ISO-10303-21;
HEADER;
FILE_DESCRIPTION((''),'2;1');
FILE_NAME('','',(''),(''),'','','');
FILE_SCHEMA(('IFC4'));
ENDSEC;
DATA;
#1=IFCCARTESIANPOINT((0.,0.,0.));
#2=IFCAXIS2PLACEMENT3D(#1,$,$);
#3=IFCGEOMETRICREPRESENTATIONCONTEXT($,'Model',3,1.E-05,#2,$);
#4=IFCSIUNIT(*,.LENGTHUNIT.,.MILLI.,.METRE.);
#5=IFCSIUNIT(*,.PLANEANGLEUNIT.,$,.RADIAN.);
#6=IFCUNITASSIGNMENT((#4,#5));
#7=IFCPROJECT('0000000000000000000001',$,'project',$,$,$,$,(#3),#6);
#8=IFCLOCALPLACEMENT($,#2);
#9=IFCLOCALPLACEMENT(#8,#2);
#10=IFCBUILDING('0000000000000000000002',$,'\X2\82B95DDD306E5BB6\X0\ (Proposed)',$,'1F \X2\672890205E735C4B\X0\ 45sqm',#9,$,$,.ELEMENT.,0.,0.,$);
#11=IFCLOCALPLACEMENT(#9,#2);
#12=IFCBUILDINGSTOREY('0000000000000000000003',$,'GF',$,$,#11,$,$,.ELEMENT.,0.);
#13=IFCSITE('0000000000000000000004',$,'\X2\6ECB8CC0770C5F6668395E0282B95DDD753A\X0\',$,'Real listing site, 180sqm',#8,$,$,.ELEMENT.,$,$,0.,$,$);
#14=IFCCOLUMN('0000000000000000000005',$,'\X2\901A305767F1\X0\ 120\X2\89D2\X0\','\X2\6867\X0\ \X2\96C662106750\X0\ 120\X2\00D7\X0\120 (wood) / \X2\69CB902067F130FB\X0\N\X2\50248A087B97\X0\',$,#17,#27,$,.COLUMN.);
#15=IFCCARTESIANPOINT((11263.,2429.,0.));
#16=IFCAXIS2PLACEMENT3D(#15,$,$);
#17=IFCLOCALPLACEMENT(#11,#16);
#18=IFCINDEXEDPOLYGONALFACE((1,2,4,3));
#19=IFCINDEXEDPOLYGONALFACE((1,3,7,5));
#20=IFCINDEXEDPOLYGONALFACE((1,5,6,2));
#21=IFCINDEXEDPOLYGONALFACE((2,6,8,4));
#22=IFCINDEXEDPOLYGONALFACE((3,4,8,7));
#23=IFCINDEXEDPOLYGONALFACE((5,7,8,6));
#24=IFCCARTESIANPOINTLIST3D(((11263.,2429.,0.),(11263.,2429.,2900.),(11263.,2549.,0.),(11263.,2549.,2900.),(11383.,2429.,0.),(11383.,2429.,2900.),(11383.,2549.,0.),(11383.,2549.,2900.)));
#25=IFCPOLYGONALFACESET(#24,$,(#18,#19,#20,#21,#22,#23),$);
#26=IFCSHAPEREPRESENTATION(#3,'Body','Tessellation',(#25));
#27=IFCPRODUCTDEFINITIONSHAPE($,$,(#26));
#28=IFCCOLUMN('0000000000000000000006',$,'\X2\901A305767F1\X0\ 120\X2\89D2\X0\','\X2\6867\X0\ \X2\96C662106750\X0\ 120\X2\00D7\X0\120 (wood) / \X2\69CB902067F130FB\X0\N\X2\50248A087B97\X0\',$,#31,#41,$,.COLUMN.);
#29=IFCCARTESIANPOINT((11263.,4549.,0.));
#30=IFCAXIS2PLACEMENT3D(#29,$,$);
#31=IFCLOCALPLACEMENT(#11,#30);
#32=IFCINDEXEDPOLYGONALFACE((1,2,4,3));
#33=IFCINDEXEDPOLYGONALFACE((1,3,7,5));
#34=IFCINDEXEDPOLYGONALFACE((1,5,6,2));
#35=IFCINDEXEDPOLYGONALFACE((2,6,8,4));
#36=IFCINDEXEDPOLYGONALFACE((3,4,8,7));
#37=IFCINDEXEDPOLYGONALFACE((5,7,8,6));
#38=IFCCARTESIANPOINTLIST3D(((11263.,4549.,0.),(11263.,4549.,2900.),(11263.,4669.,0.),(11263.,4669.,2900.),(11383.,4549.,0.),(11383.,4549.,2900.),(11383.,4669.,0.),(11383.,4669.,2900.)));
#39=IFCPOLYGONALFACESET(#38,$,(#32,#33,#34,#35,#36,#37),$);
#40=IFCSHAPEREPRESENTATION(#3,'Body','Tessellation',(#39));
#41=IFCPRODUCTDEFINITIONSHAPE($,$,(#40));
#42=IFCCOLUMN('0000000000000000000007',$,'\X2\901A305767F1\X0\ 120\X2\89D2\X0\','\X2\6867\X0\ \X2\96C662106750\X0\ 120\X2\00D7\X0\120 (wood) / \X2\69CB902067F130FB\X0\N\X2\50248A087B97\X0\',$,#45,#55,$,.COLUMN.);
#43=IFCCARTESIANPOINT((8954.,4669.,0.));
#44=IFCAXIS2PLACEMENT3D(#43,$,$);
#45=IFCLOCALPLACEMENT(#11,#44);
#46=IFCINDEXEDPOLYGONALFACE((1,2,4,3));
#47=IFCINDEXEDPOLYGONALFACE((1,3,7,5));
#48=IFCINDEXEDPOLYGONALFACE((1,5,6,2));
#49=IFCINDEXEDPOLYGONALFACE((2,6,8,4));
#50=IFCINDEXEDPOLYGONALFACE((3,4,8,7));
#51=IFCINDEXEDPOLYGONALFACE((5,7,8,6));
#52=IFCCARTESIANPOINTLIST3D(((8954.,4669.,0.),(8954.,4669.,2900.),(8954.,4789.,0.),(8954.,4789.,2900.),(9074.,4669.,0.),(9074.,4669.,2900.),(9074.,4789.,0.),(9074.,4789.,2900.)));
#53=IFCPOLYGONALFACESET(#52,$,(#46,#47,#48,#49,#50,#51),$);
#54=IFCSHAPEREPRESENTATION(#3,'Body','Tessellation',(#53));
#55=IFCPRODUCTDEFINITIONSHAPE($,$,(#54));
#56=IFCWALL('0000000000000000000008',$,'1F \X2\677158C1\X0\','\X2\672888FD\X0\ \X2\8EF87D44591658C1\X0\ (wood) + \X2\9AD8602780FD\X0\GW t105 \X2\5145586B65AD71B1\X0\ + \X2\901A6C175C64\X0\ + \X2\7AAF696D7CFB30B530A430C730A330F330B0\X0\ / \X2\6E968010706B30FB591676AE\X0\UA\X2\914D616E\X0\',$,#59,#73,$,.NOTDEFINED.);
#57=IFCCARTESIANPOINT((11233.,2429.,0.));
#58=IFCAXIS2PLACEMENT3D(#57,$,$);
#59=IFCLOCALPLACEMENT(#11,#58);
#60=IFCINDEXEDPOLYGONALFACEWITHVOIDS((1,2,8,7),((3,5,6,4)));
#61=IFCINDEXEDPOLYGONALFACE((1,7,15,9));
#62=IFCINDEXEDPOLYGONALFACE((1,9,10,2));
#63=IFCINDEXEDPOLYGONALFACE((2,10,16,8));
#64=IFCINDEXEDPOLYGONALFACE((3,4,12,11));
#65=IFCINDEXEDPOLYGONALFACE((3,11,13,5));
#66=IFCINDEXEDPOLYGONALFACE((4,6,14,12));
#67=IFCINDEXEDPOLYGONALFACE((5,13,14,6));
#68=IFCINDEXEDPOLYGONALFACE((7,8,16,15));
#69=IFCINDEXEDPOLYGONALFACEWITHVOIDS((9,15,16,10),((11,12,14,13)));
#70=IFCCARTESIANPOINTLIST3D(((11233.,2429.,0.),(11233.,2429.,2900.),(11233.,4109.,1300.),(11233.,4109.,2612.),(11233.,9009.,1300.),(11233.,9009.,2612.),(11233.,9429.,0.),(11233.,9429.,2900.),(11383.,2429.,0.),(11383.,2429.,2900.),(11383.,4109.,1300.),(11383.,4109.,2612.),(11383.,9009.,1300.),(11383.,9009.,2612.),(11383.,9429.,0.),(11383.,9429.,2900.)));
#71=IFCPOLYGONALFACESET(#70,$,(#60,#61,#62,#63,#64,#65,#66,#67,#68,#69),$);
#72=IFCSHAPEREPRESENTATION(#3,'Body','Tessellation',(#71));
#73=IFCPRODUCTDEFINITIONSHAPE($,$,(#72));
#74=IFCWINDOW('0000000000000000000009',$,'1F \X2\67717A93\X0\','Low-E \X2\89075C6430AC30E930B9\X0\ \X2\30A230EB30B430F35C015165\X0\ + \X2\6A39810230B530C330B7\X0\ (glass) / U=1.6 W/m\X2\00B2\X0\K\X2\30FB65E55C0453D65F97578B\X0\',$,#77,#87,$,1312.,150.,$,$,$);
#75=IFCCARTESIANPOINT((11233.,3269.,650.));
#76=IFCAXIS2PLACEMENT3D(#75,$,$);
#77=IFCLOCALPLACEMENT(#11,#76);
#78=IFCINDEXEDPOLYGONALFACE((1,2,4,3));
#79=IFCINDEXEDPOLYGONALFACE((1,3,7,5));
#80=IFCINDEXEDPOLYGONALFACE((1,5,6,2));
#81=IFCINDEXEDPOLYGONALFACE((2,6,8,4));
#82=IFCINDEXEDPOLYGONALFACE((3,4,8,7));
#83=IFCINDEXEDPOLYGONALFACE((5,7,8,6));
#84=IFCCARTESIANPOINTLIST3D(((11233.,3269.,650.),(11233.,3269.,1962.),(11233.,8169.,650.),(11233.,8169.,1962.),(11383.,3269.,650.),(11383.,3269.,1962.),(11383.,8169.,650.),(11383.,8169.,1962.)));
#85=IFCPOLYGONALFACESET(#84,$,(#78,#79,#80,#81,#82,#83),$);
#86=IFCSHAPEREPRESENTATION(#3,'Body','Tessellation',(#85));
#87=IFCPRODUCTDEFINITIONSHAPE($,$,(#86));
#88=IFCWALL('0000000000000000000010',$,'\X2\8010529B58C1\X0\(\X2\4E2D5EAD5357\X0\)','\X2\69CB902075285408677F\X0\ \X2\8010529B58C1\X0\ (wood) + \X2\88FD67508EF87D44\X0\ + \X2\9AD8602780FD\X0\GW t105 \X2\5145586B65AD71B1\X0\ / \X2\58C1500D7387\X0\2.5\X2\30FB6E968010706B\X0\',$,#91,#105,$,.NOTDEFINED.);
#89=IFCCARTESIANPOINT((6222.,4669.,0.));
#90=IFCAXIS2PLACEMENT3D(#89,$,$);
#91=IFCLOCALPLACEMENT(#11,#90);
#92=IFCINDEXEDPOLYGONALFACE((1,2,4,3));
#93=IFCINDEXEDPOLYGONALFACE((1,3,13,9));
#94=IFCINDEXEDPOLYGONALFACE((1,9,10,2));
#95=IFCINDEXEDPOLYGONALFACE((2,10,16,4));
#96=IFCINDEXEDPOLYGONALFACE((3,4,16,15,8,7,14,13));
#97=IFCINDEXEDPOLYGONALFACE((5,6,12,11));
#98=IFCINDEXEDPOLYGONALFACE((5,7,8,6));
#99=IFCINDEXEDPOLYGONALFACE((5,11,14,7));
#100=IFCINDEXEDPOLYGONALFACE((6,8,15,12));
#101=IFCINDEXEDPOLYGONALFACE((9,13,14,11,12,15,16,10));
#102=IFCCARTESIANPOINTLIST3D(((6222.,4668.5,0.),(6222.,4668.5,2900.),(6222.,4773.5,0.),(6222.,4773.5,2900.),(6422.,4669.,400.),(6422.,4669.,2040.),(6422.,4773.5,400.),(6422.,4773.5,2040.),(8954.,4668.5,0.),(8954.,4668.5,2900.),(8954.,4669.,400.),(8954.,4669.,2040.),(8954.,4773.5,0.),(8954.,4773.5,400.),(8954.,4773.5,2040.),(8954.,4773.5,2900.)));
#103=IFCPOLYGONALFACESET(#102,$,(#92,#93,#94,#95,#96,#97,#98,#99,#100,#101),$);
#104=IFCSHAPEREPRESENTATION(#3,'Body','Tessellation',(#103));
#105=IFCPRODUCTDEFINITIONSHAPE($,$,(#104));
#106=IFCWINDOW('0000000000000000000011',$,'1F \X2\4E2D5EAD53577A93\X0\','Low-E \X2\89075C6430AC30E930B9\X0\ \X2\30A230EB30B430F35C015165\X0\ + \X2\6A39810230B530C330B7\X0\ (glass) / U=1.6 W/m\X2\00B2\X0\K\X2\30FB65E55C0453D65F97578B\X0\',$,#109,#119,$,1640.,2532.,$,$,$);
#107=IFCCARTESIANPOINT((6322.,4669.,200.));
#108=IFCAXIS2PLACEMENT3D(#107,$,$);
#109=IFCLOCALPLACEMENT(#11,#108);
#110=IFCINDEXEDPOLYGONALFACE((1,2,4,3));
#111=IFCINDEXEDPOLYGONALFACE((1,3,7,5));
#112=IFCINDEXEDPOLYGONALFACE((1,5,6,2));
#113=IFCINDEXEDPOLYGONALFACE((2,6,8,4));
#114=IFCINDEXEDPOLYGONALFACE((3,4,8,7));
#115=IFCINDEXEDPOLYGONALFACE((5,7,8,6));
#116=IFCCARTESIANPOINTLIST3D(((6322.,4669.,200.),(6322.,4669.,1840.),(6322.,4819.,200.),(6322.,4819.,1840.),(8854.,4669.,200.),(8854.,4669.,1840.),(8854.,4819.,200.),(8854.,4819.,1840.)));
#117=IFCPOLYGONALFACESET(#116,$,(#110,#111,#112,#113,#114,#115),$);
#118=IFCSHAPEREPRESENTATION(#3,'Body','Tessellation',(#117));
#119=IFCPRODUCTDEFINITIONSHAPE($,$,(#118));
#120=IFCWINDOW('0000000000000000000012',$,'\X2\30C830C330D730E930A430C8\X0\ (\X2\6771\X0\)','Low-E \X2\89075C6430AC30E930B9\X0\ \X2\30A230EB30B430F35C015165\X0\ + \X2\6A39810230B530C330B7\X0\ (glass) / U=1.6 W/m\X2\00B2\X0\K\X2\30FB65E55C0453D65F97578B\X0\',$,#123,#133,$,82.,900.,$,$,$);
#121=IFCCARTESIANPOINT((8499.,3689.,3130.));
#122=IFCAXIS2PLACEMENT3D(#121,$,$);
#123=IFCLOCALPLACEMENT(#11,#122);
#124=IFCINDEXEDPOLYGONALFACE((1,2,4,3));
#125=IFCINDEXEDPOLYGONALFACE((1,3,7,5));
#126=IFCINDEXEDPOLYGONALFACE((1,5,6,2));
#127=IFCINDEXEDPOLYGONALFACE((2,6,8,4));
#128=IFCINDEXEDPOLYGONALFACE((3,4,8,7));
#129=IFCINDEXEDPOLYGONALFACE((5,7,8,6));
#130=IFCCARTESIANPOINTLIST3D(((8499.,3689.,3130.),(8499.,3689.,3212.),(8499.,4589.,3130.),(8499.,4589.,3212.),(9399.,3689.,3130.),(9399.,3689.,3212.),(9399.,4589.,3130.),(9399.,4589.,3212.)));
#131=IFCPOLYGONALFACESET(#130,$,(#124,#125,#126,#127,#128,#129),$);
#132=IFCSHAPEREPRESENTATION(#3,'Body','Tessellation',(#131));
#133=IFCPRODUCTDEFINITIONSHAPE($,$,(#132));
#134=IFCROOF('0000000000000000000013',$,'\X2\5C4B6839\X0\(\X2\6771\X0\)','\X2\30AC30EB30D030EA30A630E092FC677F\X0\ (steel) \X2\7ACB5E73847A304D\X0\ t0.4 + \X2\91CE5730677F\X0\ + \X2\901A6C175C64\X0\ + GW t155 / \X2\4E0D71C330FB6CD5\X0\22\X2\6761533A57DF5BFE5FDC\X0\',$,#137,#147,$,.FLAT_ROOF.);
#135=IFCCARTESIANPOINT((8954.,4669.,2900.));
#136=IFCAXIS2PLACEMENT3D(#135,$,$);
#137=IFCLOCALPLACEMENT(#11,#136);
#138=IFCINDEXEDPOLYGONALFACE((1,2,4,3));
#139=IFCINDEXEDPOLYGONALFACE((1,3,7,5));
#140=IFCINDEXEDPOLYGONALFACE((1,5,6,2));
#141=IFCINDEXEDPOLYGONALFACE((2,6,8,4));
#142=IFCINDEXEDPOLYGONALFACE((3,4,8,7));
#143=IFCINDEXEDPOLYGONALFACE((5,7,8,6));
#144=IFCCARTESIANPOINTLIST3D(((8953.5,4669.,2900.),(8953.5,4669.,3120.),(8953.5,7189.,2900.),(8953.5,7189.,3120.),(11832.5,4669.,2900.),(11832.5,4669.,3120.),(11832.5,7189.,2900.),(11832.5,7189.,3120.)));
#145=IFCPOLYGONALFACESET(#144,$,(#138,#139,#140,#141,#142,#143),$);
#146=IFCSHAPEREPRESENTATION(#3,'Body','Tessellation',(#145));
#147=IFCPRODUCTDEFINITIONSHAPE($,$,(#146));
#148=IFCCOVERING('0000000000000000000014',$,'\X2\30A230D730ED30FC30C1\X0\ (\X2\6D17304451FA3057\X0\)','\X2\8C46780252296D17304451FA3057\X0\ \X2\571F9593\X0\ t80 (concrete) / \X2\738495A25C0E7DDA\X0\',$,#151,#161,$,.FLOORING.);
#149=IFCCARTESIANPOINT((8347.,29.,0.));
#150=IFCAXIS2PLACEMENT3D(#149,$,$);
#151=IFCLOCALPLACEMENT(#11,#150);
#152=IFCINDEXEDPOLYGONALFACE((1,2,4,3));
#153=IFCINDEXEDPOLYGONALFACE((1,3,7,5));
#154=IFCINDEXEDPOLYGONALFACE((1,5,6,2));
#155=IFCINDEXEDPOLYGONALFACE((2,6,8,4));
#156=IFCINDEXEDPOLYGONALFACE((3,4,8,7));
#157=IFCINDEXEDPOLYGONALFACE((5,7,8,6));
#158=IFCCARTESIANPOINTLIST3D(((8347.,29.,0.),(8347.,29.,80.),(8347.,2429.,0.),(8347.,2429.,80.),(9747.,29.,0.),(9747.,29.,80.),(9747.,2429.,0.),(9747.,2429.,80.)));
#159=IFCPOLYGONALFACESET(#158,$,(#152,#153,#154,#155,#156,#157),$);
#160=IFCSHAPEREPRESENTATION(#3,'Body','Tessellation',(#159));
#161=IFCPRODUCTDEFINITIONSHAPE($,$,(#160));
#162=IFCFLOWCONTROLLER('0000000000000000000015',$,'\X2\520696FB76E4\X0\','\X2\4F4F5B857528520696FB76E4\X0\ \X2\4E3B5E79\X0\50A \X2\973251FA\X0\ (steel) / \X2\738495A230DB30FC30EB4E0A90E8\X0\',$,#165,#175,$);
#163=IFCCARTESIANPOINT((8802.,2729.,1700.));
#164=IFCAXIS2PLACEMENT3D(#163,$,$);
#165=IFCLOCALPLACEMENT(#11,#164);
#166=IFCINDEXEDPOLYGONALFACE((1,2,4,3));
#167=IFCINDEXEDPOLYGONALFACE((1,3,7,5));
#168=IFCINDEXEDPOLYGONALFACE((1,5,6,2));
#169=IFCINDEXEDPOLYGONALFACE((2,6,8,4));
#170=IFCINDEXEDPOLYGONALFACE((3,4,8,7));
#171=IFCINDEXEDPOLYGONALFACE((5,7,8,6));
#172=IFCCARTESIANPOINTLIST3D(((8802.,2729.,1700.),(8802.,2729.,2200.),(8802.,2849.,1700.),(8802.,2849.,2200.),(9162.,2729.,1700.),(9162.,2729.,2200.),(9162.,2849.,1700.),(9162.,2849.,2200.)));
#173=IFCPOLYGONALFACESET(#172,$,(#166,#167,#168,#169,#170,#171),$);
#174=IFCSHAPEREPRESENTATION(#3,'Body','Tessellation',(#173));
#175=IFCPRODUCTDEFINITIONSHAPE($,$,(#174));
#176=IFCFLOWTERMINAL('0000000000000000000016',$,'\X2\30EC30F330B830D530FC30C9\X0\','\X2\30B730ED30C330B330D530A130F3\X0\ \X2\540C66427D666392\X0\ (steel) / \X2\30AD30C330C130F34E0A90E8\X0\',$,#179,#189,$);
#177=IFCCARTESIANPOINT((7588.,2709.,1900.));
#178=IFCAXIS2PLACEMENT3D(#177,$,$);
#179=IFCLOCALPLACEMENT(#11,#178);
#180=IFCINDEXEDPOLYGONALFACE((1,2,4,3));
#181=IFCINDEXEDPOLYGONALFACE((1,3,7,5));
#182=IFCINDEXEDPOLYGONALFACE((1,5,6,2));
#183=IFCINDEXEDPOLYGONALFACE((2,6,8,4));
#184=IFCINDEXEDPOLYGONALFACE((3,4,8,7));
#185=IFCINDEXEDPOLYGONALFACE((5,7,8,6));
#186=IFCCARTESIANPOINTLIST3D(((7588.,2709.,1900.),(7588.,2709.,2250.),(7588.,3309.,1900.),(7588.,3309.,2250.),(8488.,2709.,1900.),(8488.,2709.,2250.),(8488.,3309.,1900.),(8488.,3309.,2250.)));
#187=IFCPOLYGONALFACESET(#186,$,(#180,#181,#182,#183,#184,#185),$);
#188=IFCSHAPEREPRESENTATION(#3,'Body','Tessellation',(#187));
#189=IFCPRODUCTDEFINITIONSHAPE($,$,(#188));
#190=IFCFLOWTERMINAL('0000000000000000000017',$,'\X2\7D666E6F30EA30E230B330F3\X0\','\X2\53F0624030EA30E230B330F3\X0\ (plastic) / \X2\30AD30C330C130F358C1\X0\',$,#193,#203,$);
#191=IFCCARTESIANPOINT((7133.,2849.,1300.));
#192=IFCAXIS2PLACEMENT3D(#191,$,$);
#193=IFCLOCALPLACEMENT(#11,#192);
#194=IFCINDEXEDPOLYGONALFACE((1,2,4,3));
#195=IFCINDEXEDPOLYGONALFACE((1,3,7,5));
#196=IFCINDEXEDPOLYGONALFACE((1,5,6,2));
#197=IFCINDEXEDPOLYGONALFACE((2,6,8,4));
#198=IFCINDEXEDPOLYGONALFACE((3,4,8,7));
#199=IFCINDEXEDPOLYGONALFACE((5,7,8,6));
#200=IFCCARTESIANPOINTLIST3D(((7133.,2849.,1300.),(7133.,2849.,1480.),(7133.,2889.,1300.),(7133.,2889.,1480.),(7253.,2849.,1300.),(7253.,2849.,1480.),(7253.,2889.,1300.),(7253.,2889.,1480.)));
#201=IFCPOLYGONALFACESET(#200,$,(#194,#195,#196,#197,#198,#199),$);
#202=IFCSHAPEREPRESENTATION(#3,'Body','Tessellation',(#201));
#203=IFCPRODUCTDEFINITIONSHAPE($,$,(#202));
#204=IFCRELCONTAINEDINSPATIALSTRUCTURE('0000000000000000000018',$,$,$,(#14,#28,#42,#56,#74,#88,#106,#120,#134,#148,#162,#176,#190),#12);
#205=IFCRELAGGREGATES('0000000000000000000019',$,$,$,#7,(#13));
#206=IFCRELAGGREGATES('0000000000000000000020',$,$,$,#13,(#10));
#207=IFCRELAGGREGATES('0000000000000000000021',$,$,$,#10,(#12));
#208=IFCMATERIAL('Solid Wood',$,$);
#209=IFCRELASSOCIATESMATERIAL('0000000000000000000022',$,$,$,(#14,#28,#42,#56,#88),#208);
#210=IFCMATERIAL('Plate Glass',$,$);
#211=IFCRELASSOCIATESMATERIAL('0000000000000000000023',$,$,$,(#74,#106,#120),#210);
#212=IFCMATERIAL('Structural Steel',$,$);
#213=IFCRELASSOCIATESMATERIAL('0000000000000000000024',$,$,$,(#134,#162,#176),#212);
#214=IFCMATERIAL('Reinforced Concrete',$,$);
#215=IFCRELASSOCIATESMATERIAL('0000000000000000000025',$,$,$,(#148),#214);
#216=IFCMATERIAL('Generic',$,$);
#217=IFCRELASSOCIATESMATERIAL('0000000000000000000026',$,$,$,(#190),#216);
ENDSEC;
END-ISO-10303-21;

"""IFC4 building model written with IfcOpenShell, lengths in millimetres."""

from ifc_helpers import new_model, si_unit, frame, frame_2d, origin, place, context, project, spatial, rectangle, extrude, material, element, fill, save


model = new_model("IFC4")

# Units and contexts
model_context = context("Model", 3, precision=1e-05, world=origin())
ifc_project = project(units=[si_unit("LENGTHUNIT", "METRE", prefix="MILLI"), si_unit("PLANEANGLEUNIT", "RADIAN")], contexts=[model_context])

# Site, building, storey
site_placement = place(None, origin())
site = spatial("IfcSite", under=ifc_project, at=site_placement, Name="滋賀県彦根市芹川町", ObjectType="Real listing site, 180sqm", CompositionType="ELEMENT", RefElevation=0.0)
building_placement = place(site_placement, origin())
building = spatial("IfcBuilding", under=site, at=building_placement, Name="芹川の家 (Proposed)", ObjectType="1F 木造平屋 45sqm", CompositionType="ELEMENT", ElevationOfRefHeight=0.0, ElevationOfTerrain=0.0)
storey_placement = place(building_placement, origin())
storey = spatial("IfcBuildingStorey", under=building, at=storey_placement, Name="GF", CompositionType="ELEMENT", Elevation=0.0)

# Columns
ifc_material_1 = material(Name="Solid Wood")
column_1_placement = place(storey_placement, frame((11263.0, 2429.0, 0.0)))
element("IfcColumn", 1, at=column_1_placement, inside=storey, material=ifc_material_1, Name="通し柱 120角", Description="桧 集成材 120×120 (wood) / 構造柱・N値計算", PredefinedType="COLUMN", context=model_context, shape_type="SweptSolid", body=[
    extrude(rectangle(XDim=120.0, YDim=120.0, at=frame_2d((60.0, 60.0))), frame((11263.0, 2429.0, 0.0)), (0.0, 0.0, 1.0), 2900.0),
])
column_2_placement = place(storey_placement, frame((11263.0, 4549.0, 0.0)))
element("IfcColumn", 2, at=column_2_placement, inside=storey, material=ifc_material_1, Name="通し柱 120角", Description="桧 集成材 120×120 (wood) / 構造柱・N値計算", PredefinedType="COLUMN", context=model_context, shape_type="SweptSolid", body=[
    extrude(rectangle(XDim=120.0, YDim=120.0, at=frame_2d((60.0, 60.0))), frame((11263.0, 4549.0, 0.0)), (0.0, 0.0, 1.0), 2900.0),
])
column_3_placement = place(storey_placement, frame((8954.0, 4669.0, 0.0)))
element("IfcColumn", 3, at=column_3_placement, inside=storey, material=ifc_material_1, Name="通し柱 120角", Description="桧 集成材 120×120 (wood) / 構造柱・N値計算", PredefinedType="COLUMN", context=model_context, shape_type="SweptSolid", body=[
    extrude(rectangle(XDim=120.0, YDim=120.0, at=frame_2d((60.0, 60.0))), frame((8954.0, 4669.0, 0.0)), (0.0, 0.0, 1.0), 2900.0),
])

# Walls, openings, windows
wall_1_placement = place(storey_placement, frame((11233.0, 2429.0, 0.0)))
wall_1 = element("IfcWall", 4, at=wall_1_placement, inside=storey, material=ifc_material_1, Name="1F 東壁", Description="木製 軸組外壁 (wood) + 高性能GW t105 充填断熱 + 通気層 + 窯業系サイディング / 準耐火・外皮UA配慮", PredefinedType="NOTDEFINED", context=model_context, shape_type="SweptSolid", body=[
    extrude(rectangle(XDim=150.0, YDim=7000.0, at=frame_2d((75.0, 3500.0))), frame((11233.0, 2429.0, 0.0)), (0.0, 0.0, 1.0), 2900.0),
])
opening_1_placement = place(storey_placement, frame((11233.0, 3269.0, 650.0)))
opening_1 = element("IfcOpeningElement", 5, at=opening_1_placement, cuts=wall_1, PredefinedType="NOTDEFINED", context=model_context, shape_type="SweptSolid", body=[
    extrude(rectangle(XDim=150.0, YDim=4900.0, at=frame_2d((75.0, 2450.0))), frame((11233.0, 3269.0, 650.0)), (0.0, 0.0, 1.0), 1312.0),
])
ifc_material_2 = material(Name="Plate Glass")
window_1_placement = place(storey_placement, frame((11233.0, 3269.0, 650.0)))
window_1 = element("IfcWindow", 6, at=window_1_placement, inside=storey, material=ifc_material_2, Name="1F 東窓", Description="Low-E 複層ガラス アルゴン封入 + 樹脂サッシ (glass) / U=1.6 W/m²K・日射取得型", OverallHeight=1312.0, OverallWidth=150.0, context=model_context, shape_type="SweptSolid", body=[
    extrude(rectangle(XDim=150.0, YDim=4900.0, at=frame_2d((75.0, 2450.0))), frame((11233.0, 3269.0, 650.0)), (0.0, 0.0, 1.0), 1312.0),
])
fill(opening_1, window_1)
wall_2_placement = place(storey_placement, frame((6222.0, 4669.0, 0.0)))
wall_2 = element("IfcWall", 7, at=wall_2_placement, inside=storey, material=ifc_material_1, Name="耐力壁(中庭南)", Description="構造用合板 耐力壁 (wood) + 製材軸組 + 高性能GW t105 充填断熱 / 壁倍率2.5・準耐火", PredefinedType="NOTDEFINED", context=model_context, shape_type="SweptSolid", body=[
    extrude(rectangle(XDim=2732.0, YDim=105.0, at=frame_2d((1366.0, 52.0))), frame((6222.0, 4669.0, 0.0)), (0.0, 0.0, 1.0), 2900.0),
])
opening_2_placement = place(storey_placement, frame((6322.0, 4669.0, 200.0)))
opening_2 = element("IfcOpeningElement", 8, at=opening_2_placement, cuts=wall_2, PredefinedType="NOTDEFINED", context=model_context, shape_type="SweptSolid", body=[
    extrude(rectangle(XDim=2532.0, YDim=150.0, at=frame_2d((1266.0, 75.0))), frame((6322.0, 4669.0, 200.0)), (0.0, 0.0, 1.0), 1640.0),
])
window_2_placement = place(storey_placement, frame((6322.0, 4669.0, 200.0)))
window_2 = element("IfcWindow", 9, at=window_2_placement, inside=storey, material=ifc_material_2, Name="1F 中庭南窓", Description="Low-E 複層ガラス アルゴン封入 + 樹脂サッシ (glass) / U=1.6 W/m²K・日射取得型", OverallHeight=1640.0, OverallWidth=2532.0, context=model_context, shape_type="SweptSolid", body=[
    extrude(rectangle(XDim=2532.0, YDim=150.0, at=frame_2d((1266.0, 75.0))), frame((6322.0, 4669.0, 200.0)), (0.0, 0.0, 1.0), 1640.0),
])
fill(opening_2, window_2)

# Window
window_3_placement = place(storey_placement, frame((8499.0, 3689.0, 3130.0)))
element("IfcWindow", 10, at=window_3_placement, inside=storey, material=ifc_material_2, Name="トップライト (東)", Description="Low-E 複層ガラス アルゴン封入 + 樹脂サッシ (glass) / U=1.6 W/m²K・日射取得型", OverallHeight=82.0, OverallWidth=900.0, context=model_context, shape_type="SweptSolid", body=[
    extrude(rectangle(XDim=900.0, YDim=900.0, at=frame_2d((450.0, 450.0))), frame((8499.0, 3689.0, 3130.0)), (0.0, 0.0, 1.0), 82.0),
])

# Roof
ifc_material_3 = material(Name="Structural Steel")
roof_placement = place(storey_placement, frame((8954.0, 4669.0, 2900.0)))
element("IfcRoof", 11, at=roof_placement, inside=storey, material=ifc_material_3, Name="屋根(東)", Description="ガルバリウム鋼板 (steel) 立平葺き t0.4 + 野地板 + 通気層 + GW t155 / 不燃・法22条区域対応", PredefinedType="FLAT_ROOF", context=model_context, shape_type="SweptSolid", body=[
    extrude(rectangle(XDim=2879.0, YDim=2520.0, at=frame_2d((1439.0, 1260.0))), frame((8954.0, 4669.0, 2900.0)), (0.0, 0.0, 1.0), 220.0),
])

# Covering
ifc_material_4 = material(Name="Reinforced Concrete")
covering_placement = place(storey_placement, frame((8347.0, 29.0, 0.0)))
element("IfcCovering", 12, at=covering_placement, inside=storey, material=ifc_material_4, Name="アプローチ (洗い出し)", Description="豆砂利洗い出し 土間 t80 (concrete) / 玄関導線", PredefinedType="FLOORING", context=model_context, shape_type="SweptSolid", body=[
    extrude(rectangle(XDim=1400.0, YDim=2400.0, at=frame_2d((700.0, 1200.0))), frame((8347.0, 29.0, 0.0)), (0.0, 0.0, 1.0), 80.0),
])

# Flow controller
flow_controller_placement = place(storey_placement, frame((8802.0, 2729.0, 1700.0)))
element("IfcFlowController", 13, at=flow_controller_placement, inside=storey, material=ifc_material_3, Name="分電盤", Description="住宅用分電盤 主幹50A 露出 (steel) / 玄関ホール上部", context=model_context, shape_type="SweptSolid", body=[
    extrude(rectangle(XDim=360.0, YDim=120.0, at=frame_2d((180.0, 60.0))), frame((8802.0, 2729.0, 1700.0)), (0.0, 0.0, 1.0), 500.0),
])

# Flow terminals
flow_terminal_1_placement = place(storey_placement, frame((7588.0, 2709.0, 1900.0)))
element("IfcFlowTerminal", 14, at=flow_terminal_1_placement, inside=storey, material=ifc_material_3, Name="レンジフード", Description="シロッコファン 同時給排 (steel) / キッチン上部", context=model_context, shape_type="SweptSolid", body=[
    extrude(rectangle(XDim=900.0, YDim=600.0, at=frame_2d((450.0, 300.0))), frame((7588.0, 2709.0, 1900.0)), (0.0, 0.0, 1.0), 350.0),
])
ifc_material_5 = material(Name="Generic")
flow_terminal_2_placement = place(storey_placement, frame((7133.0, 2849.0, 1300.0)))
element("IfcFlowTerminal", 15, at=flow_terminal_2_placement, inside=storey, material=ifc_material_5, Name="給湯リモコン", Description="台所リモコン (plastic) / キッチン壁", context=model_context, shape_type="SweptSolid", body=[
    extrude(rectangle(XDim=120.0, YDim=40.0, at=frame_2d((60.0, 20.0))), frame((7133.0, 2849.0, 1300.0)), (0.0, 0.0, 1.0), 180.0),
])

save(model, "model.ifc")
